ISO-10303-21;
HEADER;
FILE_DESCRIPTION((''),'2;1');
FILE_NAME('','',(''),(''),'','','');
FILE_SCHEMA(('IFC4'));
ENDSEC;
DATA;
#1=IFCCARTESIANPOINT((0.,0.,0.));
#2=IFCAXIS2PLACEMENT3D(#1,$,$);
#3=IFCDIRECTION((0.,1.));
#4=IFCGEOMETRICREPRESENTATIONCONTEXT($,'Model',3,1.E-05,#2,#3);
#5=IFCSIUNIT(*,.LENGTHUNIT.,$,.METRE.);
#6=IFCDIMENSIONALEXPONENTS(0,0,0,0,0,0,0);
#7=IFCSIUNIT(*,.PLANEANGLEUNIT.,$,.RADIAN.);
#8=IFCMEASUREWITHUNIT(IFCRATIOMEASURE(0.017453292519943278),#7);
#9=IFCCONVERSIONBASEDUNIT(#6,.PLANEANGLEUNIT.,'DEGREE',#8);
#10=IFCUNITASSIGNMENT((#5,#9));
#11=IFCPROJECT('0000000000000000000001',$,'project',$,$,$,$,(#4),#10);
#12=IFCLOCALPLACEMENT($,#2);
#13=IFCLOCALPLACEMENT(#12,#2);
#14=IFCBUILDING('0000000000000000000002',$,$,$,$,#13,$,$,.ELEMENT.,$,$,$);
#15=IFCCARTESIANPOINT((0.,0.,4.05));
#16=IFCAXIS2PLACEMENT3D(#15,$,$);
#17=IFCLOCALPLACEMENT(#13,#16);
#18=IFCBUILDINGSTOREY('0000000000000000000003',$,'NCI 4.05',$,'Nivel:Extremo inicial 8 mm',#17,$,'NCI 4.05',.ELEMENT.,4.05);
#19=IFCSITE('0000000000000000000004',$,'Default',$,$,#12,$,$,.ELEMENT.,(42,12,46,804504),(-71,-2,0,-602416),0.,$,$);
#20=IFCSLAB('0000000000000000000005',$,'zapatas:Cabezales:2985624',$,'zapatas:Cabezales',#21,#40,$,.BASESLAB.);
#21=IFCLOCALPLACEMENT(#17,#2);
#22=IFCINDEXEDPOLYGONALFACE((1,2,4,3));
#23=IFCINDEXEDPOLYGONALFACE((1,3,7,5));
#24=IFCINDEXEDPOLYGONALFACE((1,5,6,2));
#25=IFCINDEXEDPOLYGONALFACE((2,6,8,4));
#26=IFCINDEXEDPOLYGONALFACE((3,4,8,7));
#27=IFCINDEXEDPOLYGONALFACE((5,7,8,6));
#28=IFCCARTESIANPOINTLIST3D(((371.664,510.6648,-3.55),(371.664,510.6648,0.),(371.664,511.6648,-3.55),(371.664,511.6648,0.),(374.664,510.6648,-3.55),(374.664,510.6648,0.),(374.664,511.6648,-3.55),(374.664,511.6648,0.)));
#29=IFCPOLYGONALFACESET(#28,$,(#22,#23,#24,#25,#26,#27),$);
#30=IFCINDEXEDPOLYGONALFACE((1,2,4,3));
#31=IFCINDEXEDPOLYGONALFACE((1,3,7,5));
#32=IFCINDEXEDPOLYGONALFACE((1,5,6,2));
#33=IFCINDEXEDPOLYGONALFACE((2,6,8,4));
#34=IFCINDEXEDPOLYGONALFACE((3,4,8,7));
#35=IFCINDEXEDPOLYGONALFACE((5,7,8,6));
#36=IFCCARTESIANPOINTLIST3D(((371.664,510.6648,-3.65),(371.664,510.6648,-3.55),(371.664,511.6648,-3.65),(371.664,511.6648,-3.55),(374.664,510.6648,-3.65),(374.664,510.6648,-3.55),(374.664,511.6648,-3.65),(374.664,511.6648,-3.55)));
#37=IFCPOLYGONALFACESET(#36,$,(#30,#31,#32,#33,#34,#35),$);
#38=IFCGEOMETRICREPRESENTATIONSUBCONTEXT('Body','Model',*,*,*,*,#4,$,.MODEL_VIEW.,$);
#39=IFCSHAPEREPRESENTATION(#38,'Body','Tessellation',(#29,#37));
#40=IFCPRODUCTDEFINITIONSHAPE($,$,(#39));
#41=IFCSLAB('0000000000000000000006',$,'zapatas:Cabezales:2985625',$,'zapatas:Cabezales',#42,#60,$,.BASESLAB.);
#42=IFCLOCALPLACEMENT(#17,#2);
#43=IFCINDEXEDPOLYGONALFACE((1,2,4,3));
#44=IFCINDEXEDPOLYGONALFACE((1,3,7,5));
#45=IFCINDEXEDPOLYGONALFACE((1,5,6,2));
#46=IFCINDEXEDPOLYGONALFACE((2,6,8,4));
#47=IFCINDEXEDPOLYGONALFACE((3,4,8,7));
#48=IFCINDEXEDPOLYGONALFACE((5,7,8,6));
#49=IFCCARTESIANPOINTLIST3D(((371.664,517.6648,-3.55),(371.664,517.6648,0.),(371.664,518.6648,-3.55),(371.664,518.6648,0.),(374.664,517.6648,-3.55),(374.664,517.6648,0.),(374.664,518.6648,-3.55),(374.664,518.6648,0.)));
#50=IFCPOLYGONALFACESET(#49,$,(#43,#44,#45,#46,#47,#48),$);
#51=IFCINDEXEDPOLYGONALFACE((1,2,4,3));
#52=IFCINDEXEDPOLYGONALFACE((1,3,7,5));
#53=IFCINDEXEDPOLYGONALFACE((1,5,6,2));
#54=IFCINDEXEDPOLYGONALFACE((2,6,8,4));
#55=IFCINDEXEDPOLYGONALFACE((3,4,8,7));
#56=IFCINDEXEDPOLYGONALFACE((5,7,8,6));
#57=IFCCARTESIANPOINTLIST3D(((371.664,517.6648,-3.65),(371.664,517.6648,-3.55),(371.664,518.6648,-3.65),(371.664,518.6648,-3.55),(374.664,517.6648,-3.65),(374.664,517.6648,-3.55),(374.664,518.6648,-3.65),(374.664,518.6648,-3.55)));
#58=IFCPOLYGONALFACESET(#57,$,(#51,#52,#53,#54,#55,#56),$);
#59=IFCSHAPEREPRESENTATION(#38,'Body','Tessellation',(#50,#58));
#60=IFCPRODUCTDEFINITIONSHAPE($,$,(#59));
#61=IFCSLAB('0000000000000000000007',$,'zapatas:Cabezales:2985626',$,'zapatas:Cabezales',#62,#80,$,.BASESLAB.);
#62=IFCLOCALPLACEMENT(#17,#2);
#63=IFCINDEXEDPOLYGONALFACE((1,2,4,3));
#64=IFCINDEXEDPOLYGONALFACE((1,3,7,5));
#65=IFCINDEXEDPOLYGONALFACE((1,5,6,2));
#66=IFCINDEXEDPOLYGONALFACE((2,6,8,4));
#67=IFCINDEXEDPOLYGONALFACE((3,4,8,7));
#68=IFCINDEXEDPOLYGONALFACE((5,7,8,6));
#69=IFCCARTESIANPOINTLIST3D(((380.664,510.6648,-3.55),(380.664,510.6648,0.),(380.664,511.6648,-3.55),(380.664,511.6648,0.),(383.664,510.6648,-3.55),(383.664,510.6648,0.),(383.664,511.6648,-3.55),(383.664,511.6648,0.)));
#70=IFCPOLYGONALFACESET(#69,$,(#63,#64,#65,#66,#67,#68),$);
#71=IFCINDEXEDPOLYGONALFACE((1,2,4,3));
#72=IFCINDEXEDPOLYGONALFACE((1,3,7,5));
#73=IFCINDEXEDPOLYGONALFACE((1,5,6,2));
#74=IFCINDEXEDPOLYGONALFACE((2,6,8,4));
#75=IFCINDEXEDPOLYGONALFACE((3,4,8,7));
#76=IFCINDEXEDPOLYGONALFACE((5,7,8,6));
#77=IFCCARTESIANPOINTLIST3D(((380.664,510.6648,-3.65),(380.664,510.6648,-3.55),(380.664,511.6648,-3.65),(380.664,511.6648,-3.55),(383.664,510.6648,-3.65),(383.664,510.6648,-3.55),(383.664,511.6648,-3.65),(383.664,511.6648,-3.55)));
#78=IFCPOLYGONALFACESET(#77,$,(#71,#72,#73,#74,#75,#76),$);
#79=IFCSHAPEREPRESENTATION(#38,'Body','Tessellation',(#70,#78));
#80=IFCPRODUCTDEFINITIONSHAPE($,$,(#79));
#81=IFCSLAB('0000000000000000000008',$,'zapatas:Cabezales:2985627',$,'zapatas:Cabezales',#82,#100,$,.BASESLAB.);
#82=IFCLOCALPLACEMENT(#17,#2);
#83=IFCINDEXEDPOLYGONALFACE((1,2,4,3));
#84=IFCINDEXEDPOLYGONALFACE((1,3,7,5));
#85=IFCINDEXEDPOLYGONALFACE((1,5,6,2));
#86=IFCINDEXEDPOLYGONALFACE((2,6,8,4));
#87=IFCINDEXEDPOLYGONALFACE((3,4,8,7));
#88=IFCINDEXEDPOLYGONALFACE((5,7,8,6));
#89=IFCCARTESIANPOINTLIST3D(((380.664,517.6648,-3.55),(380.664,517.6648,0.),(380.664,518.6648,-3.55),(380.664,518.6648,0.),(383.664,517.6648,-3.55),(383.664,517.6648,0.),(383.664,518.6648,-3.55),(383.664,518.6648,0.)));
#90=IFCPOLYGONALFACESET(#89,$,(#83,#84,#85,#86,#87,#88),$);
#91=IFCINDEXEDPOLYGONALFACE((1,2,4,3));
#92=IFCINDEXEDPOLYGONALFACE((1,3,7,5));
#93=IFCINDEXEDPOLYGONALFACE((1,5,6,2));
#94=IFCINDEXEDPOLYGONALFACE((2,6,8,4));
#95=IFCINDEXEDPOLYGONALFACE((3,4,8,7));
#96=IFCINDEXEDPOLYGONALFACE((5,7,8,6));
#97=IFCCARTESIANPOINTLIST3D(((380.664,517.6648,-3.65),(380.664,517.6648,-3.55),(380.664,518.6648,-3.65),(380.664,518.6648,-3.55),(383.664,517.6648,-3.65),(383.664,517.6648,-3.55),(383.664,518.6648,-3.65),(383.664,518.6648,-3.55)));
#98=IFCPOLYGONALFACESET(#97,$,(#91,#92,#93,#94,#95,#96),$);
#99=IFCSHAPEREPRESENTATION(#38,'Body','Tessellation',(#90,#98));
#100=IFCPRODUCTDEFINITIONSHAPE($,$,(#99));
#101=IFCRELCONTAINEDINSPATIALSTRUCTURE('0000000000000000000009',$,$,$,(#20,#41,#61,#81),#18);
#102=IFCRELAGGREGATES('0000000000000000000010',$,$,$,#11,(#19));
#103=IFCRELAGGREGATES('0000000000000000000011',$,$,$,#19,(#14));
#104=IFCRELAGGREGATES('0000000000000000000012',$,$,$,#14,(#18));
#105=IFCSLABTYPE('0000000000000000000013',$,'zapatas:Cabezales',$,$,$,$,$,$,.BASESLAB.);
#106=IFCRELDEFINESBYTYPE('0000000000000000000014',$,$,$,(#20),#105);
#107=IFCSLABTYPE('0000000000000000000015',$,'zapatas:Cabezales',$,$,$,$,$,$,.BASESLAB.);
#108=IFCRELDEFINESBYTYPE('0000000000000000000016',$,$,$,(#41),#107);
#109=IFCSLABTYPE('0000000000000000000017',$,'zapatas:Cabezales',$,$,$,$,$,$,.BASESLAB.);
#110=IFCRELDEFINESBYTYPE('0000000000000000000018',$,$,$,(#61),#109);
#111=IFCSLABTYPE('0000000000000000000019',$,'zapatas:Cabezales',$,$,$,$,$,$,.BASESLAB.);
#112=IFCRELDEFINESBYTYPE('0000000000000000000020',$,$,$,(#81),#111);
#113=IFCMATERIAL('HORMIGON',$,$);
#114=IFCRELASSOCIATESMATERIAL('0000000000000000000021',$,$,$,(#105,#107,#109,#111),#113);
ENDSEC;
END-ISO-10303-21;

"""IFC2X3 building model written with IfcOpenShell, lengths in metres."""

from ifc_helpers import new_model, entity, si_unit, converted_unit, direction, frame, frame_2d, origin, place, context, subcontext, project, spatial, rectangle, extrude, material, type_object, element, save


model = new_model("IFC2X3")

# Units and contexts
model_context = context("Model", 3, precision=1e-05, world=origin(), true_north=direction((0.0, 1.0)))
body_context = subcontext(model_context, "Body", "Model", "MODEL_VIEW")
ifc_project = project(units=[si_unit("LENGTHUNIT", "METRE"), converted_unit("PLANEANGLEUNIT", "DEGREE", entity("IfcRatioMeasure", 0.017453292519943278), si_unit("PLANEANGLEUNIT", "RADIAN"), dimensions=[0, 0, 0, 0, 0, 0, 0])], contexts=[model_context])

# Site, building, storey
site_placement = place(None, origin())
site = spatial("IfcSite", under=ifc_project, at=site_placement, Name="Default", CompositionType="ELEMENT", RefLatitude=(42, 12, 46, 804504), RefLongitude=(-71, -2, 0, -602416), RefElevation=0.0)
building_placement = place(site_placement, origin())
building = spatial("IfcBuilding", under=site, at=building_placement, CompositionType="ELEMENT")
storey_placement = place(building_placement, frame((0.0, 0.0, 4.05)))
storey = spatial("IfcBuildingStorey", under=building, at=storey_placement, Name="NCI 4.05", ObjectType="Nivel:Extremo inicial 8 mm", LongName="NCI 4.05", CompositionType="ELEMENT", Elevation=4.05)

# Slabs
ifc_material_1 = material(Name="HORMIGON")
slab_type_1 = type_object("IfcSlabType", Name="zapatas:Cabezales", PredefinedType="BASESLAB", material=ifc_material_1)
slab_1_placement = place(storey_placement, origin())
element("IfcSlab", 1, at=slab_1_placement, inside=storey, type_object=slab_type_1, Name="zapatas:Cabezales:2985624", ObjectType="zapatas:Cabezales", PredefinedType="BASESLAB", context=body_context, shape_type="SweptSolid", body=[
    extrude(rectangle(XDim=1.0, YDim=3.0, at=frame_2d((0.0, 0.0), x_axis=(1.0, 0.0))), frame((373.164, 511.1648, -3.55), z_axis=(0.0, 0.0, 1.0), x_axis=(0.0, 1.0, 0.0)), (0.0, 0.0, 1.0), 3.55),
    extrude(rectangle(XDim=1.0, YDim=3.0, at=frame_2d((0.0, 0.0), x_axis=(1.0, 0.0))), frame((373.164, 511.1648, -3.65), z_axis=(0.0, 0.0, 1.0), x_axis=(0.0, 1.0, 0.0)), (0.0, 0.0, 1.0), 0.1),
])
slab_type_2 = type_object("IfcSlabType", Name="zapatas:Cabezales", PredefinedType="BASESLAB", material=ifc_material_1)
slab_2_placement = place(storey_placement, origin())
element("IfcSlab", 2, at=slab_2_placement, inside=storey, type_object=slab_type_2, Name="zapatas:Cabezales:2985625", ObjectType="zapatas:Cabezales", PredefinedType="BASESLAB", context=body_context, shape_type="SweptSolid", body=[
    extrude(rectangle(XDim=1.0, YDim=3.0, at=frame_2d((0.0, 0.0), x_axis=(1.0, 0.0))), frame((373.164, 518.1648, -3.55), z_axis=(0.0, 0.0, 1.0), x_axis=(0.0, 1.0, 0.0)), (0.0, 0.0, 1.0), 3.55),
    extrude(rectangle(XDim=1.0, YDim=3.0, at=frame_2d((0.0, 0.0), x_axis=(1.0, 0.0))), frame((373.164, 518.1648, -3.65), z_axis=(0.0, 0.0, 1.0), x_axis=(0.0, 1.0, 0.0)), (0.0, 0.0, 1.0), 0.1),
])
slab_type_3 = type_object("IfcSlabType", Name="zapatas:Cabezales", PredefinedType="BASESLAB", material=ifc_material_1)
slab_3_placement = place(storey_placement, origin())
element("IfcSlab", 3, at=slab_3_placement, inside=storey, type_object=slab_type_3, Name="zapatas:Cabezales:2985626", ObjectType="zapatas:Cabezales", PredefinedType="BASESLAB", context=body_context, shape_type="SweptSolid", body=[
    extrude(rectangle(XDim=1.0, YDim=3.0, at=frame_2d((0.0, 0.0), x_axis=(1.0, 0.0))), frame((382.164, 511.1648, -3.55), z_axis=(0.0, 0.0, 1.0), x_axis=(0.0, 1.0, 0.0)), (0.0, 0.0, 1.0), 3.55),
    extrude(rectangle(XDim=1.0, YDim=3.0, at=frame_2d((0.0, 0.0), x_axis=(1.0, 0.0))), frame((382.164, 511.1648, -3.65), z_axis=(0.0, 0.0, 1.0), x_axis=(0.0, 1.0, 0.0)), (0.0, 0.0, 1.0), 0.1),
])
slab_type_4 = type_object("IfcSlabType", Name="zapatas:Cabezales", PredefinedType="BASESLAB", material=ifc_material_1)
slab_4_placement = place(storey_placement, origin())
element("IfcSlab", 4, at=slab_4_placement, inside=storey, type_object=slab_type_4, Name="zapatas:Cabezales:2985627", ObjectType="zapatas:Cabezales", PredefinedType="BASESLAB", context=body_context, shape_type="SweptSolid", body=[
    extrude(rectangle(XDim=1.0, YDim=3.0, at=frame_2d((0.0, 0.0), x_axis=(1.0, 0.0))), frame((382.164, 518.1648, -3.55), z_axis=(0.0, 0.0, 1.0), x_axis=(0.0, 1.0, 0.0)), (0.0, 0.0, 1.0), 3.55),
    extrude(rectangle(XDim=1.0, YDim=3.0, at=frame_2d((0.0, 0.0), x_axis=(1.0, 0.0))), frame((382.164, 518.1648, -3.65), z_axis=(0.0, 0.0, 1.0), x_axis=(0.0, 1.0, 0.0)), (0.0, 0.0, 1.0), 0.1),
])

save(model, "model.ifc")
